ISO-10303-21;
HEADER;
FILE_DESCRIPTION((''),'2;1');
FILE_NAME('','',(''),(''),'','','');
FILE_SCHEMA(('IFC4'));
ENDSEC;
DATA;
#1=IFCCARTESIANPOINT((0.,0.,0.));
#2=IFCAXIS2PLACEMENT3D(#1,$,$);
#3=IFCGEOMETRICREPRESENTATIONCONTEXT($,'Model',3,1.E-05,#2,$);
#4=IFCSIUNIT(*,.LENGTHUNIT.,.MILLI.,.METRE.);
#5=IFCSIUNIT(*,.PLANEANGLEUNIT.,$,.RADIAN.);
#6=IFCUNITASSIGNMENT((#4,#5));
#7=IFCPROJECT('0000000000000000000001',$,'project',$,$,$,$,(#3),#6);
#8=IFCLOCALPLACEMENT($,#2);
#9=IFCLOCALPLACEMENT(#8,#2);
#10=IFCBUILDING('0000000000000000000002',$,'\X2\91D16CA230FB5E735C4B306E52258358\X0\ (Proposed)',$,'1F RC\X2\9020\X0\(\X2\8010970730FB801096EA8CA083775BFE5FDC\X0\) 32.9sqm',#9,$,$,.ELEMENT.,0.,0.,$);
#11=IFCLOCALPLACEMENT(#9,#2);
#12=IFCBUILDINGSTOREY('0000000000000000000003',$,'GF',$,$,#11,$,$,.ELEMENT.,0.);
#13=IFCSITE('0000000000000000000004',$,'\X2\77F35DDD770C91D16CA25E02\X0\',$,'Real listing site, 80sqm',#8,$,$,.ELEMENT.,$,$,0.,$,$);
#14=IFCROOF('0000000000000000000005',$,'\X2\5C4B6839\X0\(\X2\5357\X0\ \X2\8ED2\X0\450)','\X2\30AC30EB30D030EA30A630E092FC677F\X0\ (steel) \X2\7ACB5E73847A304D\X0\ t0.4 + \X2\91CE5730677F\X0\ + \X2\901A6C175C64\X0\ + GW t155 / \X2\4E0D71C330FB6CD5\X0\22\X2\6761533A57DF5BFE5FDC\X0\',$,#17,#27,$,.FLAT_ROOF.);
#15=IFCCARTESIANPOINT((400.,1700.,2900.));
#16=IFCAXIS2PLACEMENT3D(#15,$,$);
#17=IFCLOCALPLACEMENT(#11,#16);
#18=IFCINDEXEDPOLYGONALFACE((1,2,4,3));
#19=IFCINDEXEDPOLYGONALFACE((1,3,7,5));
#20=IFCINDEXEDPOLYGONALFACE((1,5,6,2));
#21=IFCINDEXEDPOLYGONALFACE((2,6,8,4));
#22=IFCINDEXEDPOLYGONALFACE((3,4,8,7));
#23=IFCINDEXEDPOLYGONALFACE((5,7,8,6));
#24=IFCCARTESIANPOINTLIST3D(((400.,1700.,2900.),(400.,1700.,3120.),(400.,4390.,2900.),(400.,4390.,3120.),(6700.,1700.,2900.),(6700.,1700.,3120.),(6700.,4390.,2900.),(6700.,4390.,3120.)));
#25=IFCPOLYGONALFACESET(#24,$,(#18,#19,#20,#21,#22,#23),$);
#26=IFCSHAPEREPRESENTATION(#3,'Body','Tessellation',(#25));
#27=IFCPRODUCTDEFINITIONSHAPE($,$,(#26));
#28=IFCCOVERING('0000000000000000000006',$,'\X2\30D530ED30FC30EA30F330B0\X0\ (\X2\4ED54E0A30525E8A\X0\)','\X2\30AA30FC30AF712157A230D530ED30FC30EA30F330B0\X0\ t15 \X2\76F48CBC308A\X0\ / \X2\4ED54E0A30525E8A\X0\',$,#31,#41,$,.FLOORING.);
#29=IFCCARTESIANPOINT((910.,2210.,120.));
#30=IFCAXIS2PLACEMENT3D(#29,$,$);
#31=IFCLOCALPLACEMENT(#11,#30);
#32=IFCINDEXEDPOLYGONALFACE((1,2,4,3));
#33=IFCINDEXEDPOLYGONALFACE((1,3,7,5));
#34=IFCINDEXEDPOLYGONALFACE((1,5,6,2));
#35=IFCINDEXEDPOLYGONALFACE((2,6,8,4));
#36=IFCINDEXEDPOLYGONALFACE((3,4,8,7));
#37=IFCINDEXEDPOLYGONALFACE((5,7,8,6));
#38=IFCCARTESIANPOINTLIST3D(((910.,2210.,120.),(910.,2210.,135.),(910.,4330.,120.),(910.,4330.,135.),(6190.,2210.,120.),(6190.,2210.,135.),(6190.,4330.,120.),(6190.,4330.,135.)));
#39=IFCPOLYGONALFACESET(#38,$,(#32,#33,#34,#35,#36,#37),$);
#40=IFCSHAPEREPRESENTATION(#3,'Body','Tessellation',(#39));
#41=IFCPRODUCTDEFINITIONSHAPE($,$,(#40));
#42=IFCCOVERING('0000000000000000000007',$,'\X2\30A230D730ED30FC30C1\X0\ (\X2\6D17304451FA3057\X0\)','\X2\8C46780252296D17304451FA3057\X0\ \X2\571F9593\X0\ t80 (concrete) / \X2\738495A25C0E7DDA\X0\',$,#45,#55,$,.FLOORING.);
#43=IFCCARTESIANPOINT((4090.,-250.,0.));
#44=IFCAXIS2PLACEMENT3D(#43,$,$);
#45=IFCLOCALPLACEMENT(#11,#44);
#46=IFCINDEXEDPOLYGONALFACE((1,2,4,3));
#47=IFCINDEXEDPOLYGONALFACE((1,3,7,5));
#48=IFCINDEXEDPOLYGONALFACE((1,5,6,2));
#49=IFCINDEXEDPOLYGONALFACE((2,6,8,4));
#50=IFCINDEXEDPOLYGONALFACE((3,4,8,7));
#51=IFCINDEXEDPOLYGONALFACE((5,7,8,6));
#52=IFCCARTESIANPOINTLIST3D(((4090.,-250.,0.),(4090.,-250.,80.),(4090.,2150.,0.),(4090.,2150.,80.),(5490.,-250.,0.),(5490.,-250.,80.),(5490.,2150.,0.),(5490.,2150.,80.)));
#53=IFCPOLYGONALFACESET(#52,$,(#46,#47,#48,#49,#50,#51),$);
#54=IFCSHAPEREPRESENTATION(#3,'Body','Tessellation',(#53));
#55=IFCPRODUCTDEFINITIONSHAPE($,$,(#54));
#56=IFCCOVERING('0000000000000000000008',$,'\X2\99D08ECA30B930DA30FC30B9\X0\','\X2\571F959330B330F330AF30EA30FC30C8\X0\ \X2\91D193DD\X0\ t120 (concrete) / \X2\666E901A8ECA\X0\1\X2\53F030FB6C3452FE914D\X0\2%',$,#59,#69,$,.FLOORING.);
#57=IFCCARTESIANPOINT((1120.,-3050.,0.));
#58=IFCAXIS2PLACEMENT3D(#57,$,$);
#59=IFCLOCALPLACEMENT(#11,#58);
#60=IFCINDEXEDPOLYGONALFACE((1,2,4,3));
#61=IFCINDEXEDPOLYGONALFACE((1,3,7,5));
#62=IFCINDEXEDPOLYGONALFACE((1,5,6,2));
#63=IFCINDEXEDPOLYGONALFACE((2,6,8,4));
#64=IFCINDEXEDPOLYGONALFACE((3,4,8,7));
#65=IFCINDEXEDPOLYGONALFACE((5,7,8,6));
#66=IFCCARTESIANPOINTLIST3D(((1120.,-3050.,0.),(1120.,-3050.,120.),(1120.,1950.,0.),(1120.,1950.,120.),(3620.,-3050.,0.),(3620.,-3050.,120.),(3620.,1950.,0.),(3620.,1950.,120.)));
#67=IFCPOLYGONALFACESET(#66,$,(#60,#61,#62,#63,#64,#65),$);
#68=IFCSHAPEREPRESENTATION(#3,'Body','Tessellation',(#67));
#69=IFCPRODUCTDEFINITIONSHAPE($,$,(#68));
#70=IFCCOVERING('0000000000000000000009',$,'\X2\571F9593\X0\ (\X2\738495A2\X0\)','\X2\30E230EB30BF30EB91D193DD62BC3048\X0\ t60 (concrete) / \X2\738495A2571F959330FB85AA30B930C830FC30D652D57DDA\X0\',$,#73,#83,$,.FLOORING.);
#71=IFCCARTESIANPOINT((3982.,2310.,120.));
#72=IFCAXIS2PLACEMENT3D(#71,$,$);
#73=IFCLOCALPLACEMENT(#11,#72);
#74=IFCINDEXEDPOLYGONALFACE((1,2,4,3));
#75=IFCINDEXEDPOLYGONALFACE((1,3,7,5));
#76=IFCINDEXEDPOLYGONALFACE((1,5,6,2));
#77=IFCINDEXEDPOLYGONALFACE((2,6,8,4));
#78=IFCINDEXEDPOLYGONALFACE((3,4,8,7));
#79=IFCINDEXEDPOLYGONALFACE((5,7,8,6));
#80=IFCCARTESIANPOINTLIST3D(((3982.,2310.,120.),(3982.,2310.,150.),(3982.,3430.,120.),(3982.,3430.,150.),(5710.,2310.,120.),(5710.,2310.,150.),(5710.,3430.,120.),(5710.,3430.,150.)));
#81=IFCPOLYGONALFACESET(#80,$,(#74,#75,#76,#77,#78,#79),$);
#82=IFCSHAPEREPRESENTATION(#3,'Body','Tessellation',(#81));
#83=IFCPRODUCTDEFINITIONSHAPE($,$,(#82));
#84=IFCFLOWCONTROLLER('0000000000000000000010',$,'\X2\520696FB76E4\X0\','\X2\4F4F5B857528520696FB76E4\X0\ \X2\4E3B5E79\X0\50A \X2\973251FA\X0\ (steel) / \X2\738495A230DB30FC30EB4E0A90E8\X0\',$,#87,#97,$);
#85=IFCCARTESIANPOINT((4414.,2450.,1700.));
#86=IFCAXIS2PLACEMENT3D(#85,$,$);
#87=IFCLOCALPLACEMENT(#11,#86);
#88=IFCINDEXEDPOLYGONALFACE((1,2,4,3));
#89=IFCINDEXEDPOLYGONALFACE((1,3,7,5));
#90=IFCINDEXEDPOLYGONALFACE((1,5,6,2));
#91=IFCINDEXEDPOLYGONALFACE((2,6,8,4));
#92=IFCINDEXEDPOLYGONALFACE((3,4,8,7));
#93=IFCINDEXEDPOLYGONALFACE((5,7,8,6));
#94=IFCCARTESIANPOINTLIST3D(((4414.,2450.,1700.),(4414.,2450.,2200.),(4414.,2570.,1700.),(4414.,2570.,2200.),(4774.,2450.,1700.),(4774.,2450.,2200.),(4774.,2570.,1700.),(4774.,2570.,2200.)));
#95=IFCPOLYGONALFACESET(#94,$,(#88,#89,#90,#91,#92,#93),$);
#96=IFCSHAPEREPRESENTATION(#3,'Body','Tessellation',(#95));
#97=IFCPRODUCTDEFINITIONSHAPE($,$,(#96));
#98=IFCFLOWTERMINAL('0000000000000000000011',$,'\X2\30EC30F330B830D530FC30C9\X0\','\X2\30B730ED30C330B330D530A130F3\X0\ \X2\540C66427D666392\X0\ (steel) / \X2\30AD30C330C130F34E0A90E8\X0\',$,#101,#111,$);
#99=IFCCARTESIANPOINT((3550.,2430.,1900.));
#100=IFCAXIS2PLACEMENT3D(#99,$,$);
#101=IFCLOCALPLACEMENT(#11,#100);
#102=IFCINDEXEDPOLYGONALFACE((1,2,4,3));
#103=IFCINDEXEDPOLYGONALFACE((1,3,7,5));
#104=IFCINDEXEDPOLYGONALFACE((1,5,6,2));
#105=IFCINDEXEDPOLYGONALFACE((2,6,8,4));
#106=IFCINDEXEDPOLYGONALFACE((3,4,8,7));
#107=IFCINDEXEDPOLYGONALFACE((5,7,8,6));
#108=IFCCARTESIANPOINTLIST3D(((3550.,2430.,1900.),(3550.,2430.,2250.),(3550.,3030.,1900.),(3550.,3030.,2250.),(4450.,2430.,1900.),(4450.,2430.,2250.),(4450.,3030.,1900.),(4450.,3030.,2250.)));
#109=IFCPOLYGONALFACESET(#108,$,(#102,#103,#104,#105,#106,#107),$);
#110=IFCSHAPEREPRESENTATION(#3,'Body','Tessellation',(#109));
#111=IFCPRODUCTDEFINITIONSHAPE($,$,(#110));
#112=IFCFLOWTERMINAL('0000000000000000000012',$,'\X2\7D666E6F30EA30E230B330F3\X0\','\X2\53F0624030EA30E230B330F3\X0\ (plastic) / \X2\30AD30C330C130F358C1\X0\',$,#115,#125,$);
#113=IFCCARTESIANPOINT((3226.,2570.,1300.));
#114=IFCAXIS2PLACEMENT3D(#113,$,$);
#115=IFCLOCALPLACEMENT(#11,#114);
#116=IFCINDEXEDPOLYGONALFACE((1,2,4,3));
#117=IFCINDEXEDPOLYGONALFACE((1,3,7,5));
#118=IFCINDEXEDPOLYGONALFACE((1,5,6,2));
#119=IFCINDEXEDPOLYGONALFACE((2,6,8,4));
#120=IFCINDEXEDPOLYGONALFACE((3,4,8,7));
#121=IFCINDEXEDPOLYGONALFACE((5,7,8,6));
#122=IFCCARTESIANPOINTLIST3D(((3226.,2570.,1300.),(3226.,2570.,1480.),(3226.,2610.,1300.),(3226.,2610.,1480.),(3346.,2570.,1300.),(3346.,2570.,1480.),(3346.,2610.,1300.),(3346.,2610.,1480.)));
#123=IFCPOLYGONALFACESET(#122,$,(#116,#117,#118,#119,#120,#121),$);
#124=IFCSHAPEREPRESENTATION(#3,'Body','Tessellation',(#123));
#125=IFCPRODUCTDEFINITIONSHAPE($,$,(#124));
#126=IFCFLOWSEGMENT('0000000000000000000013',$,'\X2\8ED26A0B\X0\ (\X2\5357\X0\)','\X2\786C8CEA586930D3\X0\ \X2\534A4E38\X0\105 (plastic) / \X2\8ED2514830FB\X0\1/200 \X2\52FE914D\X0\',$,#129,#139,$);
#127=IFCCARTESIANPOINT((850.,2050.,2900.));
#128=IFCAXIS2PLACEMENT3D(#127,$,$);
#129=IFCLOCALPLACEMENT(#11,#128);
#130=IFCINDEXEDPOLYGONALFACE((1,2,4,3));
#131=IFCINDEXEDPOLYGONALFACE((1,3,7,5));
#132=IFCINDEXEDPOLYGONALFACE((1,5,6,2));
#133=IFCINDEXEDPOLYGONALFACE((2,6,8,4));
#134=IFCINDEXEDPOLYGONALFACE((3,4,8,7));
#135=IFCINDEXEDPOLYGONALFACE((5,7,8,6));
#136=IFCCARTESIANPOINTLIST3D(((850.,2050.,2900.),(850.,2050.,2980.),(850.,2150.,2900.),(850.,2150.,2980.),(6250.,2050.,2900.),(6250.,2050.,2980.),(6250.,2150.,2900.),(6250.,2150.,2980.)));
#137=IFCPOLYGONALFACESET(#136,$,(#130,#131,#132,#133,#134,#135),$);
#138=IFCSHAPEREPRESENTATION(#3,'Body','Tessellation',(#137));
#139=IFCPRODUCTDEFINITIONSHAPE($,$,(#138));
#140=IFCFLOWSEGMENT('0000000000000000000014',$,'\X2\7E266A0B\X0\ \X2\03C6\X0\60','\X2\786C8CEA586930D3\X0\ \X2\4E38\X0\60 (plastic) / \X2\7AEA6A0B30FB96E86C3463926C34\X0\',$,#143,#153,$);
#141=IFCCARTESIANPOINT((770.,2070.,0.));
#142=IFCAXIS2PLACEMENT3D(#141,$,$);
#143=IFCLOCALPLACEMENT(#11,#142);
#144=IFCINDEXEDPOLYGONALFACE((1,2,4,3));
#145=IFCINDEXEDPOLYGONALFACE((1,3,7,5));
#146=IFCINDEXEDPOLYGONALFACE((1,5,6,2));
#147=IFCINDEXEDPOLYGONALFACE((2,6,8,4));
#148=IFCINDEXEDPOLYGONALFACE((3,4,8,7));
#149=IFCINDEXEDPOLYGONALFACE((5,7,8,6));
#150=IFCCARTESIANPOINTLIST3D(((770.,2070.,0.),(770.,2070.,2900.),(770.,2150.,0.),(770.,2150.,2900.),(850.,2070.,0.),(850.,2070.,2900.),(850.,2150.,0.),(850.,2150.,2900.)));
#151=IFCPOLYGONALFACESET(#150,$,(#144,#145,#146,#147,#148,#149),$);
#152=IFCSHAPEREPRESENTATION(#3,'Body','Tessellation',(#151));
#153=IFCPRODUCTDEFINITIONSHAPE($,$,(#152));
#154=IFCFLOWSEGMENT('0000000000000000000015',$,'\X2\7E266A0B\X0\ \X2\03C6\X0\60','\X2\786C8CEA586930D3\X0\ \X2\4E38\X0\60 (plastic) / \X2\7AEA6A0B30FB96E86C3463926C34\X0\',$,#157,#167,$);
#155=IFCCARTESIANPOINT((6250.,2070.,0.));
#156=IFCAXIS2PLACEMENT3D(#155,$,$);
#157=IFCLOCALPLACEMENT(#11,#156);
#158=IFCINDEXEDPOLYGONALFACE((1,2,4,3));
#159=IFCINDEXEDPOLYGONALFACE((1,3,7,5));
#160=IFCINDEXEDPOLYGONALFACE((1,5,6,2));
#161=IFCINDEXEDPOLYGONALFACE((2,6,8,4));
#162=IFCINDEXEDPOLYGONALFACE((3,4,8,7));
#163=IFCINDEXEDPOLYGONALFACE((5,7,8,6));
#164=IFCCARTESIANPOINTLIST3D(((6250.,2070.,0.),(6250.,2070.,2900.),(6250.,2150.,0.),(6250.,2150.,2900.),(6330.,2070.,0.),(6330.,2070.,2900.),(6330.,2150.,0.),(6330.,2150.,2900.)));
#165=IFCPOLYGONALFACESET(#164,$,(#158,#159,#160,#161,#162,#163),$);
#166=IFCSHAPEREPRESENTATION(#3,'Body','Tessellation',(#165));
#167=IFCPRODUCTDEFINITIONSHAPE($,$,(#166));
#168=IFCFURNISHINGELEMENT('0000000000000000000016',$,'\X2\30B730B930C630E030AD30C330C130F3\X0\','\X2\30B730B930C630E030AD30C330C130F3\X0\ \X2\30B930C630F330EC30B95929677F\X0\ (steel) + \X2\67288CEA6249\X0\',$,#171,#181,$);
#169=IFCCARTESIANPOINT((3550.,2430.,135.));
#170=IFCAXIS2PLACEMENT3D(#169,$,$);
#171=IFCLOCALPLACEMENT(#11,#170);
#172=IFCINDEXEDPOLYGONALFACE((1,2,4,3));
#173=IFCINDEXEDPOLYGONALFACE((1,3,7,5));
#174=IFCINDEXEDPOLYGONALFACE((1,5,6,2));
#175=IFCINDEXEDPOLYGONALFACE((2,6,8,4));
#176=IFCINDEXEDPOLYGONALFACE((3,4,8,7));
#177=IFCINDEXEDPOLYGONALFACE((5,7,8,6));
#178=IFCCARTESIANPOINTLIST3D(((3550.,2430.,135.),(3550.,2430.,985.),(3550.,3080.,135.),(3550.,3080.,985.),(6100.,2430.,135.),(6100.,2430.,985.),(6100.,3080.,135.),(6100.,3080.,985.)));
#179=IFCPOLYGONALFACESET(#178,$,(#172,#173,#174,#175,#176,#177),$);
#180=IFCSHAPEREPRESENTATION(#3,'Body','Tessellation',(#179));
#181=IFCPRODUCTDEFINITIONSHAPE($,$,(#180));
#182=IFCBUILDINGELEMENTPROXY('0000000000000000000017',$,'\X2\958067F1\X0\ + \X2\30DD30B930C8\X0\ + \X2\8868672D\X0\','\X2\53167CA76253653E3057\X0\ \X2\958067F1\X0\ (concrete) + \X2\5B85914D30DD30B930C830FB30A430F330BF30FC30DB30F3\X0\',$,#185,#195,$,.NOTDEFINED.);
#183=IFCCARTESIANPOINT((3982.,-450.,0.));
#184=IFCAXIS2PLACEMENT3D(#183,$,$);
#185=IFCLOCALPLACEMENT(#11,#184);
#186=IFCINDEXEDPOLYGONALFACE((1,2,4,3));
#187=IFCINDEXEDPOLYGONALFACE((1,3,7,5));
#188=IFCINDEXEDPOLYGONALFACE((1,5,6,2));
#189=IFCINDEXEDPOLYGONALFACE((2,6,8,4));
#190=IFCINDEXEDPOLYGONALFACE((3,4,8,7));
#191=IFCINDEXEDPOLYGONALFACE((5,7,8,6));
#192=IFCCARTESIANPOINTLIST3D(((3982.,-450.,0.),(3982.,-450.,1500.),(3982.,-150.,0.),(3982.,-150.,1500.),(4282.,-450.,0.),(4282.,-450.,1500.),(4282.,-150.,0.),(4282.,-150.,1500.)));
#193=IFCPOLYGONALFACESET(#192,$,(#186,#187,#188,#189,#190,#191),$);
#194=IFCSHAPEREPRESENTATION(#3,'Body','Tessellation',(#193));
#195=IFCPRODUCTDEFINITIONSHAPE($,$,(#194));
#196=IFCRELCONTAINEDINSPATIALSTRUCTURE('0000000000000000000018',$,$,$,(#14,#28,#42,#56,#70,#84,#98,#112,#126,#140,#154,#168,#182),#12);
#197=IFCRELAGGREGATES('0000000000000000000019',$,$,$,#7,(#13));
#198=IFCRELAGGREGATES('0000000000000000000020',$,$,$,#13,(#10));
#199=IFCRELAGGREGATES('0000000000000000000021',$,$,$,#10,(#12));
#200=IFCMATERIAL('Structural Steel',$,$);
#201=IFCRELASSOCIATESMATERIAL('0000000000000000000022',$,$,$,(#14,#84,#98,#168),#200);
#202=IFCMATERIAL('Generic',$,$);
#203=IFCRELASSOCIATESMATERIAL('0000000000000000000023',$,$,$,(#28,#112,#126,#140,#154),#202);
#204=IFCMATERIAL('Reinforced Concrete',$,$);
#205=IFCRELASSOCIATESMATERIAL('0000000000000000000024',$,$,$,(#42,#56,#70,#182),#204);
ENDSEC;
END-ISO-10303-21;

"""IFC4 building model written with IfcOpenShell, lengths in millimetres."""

from ifc_helpers import new_model, si_unit, frame, frame_2d, origin, place, context, project, spatial, rectangle, extrude, material, element, save


model = new_model("IFC4")

# Units and contexts
model_context = context("Model", 3, precision=1e-05, world=origin())
ifc_project = project(units=[si_unit("LENGTHUNIT", "METRE", prefix="MILLI"), si_unit("PLANEANGLEUNIT", "RADIAN")], contexts=[model_context])

# Site, building, storey
site_placement = place(None, origin())
site = spatial("IfcSite", under=ifc_project, at=site_placement, Name="石川県金沢市", ObjectType="Real listing site, 80sqm", CompositionType="ELEMENT", RefElevation=0.0)
building_placement = place(site_placement, origin())
building = spatial("IfcBuilding", under=site, at=building_placement, Name="金沢・平屋の別荘 (Proposed)", ObjectType="1F RC造(耐震・耐雪負荷対応) 32.9sqm", CompositionType="ELEMENT", ElevationOfRefHeight=0.0, ElevationOfTerrain=0.0)
storey_placement = place(building_placement, origin())
storey = spatial("IfcBuildingStorey", under=building, at=storey_placement, Name="GF", CompositionType="ELEMENT", Elevation=0.0)

# Shared definitions
ifc_material_1 = material(Name="Reinforced Concrete")

# Roof
ifc_material_2 = material(Name="Structural Steel")
roof_placement = place(storey_placement, frame((400.0, 1700.0, 2900.0)))
element("IfcRoof", 1, at=roof_placement, inside=storey, material=ifc_material_2, Name="屋根(南 軒450)", Description="ガルバリウム鋼板 (steel) 立平葺き t0.4 + 野地板 + 通気層 + GW t155 / 不燃・法22条区域対応", PredefinedType="FLAT_ROOF", context=model_context, shape_type="SweptSolid", body=[
    extrude(rectangle(XDim=6300.0, YDim=2690.0, at=frame_2d((3150.0, 1345.0))), frame((400.0, 1700.0, 2900.0)), (0.0, 0.0, 1.0), 220.0),
])

# Coverings
ifc_material_3 = material(Name="Generic")
covering_1_placement = place(storey_placement, frame((910.0, 2210.0, 120.0)))
element("IfcCovering", 2, at=covering_1_placement, inside=storey, material=ifc_material_3, Name="フローリング (仕上げ床)", Description="オーク無垢フローリング t15 直貼り / 仕上げ床", PredefinedType="FLOORING", context=model_context, shape_type="SweptSolid", body=[
    extrude(rectangle(XDim=5280.0, YDim=2120.0, at=frame_2d((2640.0, 1060.0))), frame((910.0, 2210.0, 120.0)), (0.0, 0.0, 1.0), 15.0),
])
covering_2_placement = place(storey_placement, frame((4090.0, -250.0, 0.0)))
element("IfcCovering", 3, at=covering_2_placement, inside=storey, material=ifc_material_1, Name="アプローチ (洗い出し)", Description="豆砂利洗い出し 土間 t80 (concrete) / 玄関導線", PredefinedType="FLOORING", context=model_context, shape_type="SweptSolid", body=[
    extrude(rectangle(XDim=1400.0, YDim=2400.0, at=frame_2d((700.0, 1200.0))), frame((4090.0, -250.0, 0.0)), (0.0, 0.0, 1.0), 80.0),
])
covering_3_placement = place(storey_placement, frame((1120.0, -3050.0, 0.0)))
element("IfcCovering", 4, at=covering_3_placement, inside=storey, material=ifc_material_1, Name="駐車スペース", Description="土間コンクリート 金鏝 t120 (concrete) / 普通車1台・水勾配2%", PredefinedType="FLOORING", context=model_context, shape_type="SweptSolid", body=[
    extrude(rectangle(XDim=2500.0, YDim=5000.0, at=frame_2d((1250.0, 2500.0))), frame((1120.0, -3050.0, 0.0)), (0.0, 0.0, 1.0), 120.0),
])
covering_4_placement = place(storey_placement, frame((3982.0, 2310.0, 120.0)))
element("IfcCovering", 5, at=covering_4_placement, inside=storey, material=ifc_material_1, Name="土間 (玄関)", Description="モルタル金鏝押え t60 (concrete) / 玄関土間・薪ストーブ動線", PredefinedType="FLOORING", context=model_context, shape_type="SweptSolid", body=[
    extrude(rectangle(XDim=1728.0, YDim=1120.0, at=frame_2d((864.0, 560.0))), frame((3982.0, 2310.0, 120.0)), (0.0, 0.0, 1.0), 30.0),
])

# Flow controller
flow_controller_placement = place(storey_placement, frame((4414.0, 2450.0, 1700.0)))
element("IfcFlowController", 6, at=flow_controller_placement, inside=storey, material=ifc_material_2, Name="分電盤", Description="住宅用分電盤 主幹50A 露出 (steel) / 玄関ホール上部", context=model_context, shape_type="SweptSolid", body=[
    extrude(rectangle(XDim=360.0, YDim=120.0, at=frame_2d((180.0, 60.0))), frame((4414.0, 2450.0, 1700.0)), (0.0, 0.0, 1.0), 500.0),
])

# Flow terminals
flow_terminal_1_placement = place(storey_placement, frame((3550.0, 2430.0, 1900.0)))
element("IfcFlowTerminal", 7, at=flow_terminal_1_placement, inside=storey, material=ifc_material_2, Name="レンジフード", Description="シロッコファン 同時給排 (steel) / キッチン上部", context=model_context, shape_type="SweptSolid", body=[
    extrude(rectangle(XDim=900.0, YDim=600.0, at=frame_2d((450.0, 300.0))), frame((3550.0, 2430.0, 1900.0)), (0.0, 0.0, 1.0), 350.0),
])
flow_terminal_2_placement = place(storey_placement, frame((3226.0, 2570.0, 1300.0)))
element("IfcFlowTerminal", 8, at=flow_terminal_2_placement, inside=storey, material=ifc_material_3, Name="給湯リモコン", Description="台所リモコン (plastic) / キッチン壁", context=model_context, shape_type="SweptSolid", body=[
    extrude(rectangle(XDim=120.0, YDim=40.0, at=frame_2d((60.0, 20.0))), frame((3226.0, 2570.0, 1300.0)), (0.0, 0.0, 1.0), 180.0),
])

# Flow segments
flow_segment_1_placement = place(storey_placement, frame((850.0, 2050.0, 2900.0)))
element("IfcFlowSegment", 9, at=flow_segment_1_placement, inside=storey, material=ifc_material_3, Name="軒樋 (南)", Description="硬質塩ビ 半丸105 (plastic) / 軒先・1/200 勾配", context=model_context, shape_type="SweptSolid", body=[
    extrude(rectangle(XDim=5400.0, YDim=100.0, at=frame_2d((2700.0, 50.0))), frame((850.0, 2050.0, 2900.0)), (0.0, 0.0, 1.0), 80.0),
])
flow_segment_2_placement = place(storey_placement, frame((770.0, 2070.0, 0.0)))
element("IfcFlowSegment", 10, at=flow_segment_2_placement, inside=storey, material=ifc_material_3, Name="縦樋 φ60", Description="硬質塩ビ 丸60 (plastic) / 竪樋・雨水排水", context=model_context, shape_type="SweptSolid", body=[
    extrude(rectangle(XDim=80.0, YDim=80.0, at=frame_2d((40.0, 40.0))), frame((770.0, 2070.0, 0.0)), (0.0, 0.0, 1.0), 2900.0),
])
flow_segment_3_placement = place(storey_placement, frame((6250.0, 2070.0, 0.0)))
element("IfcFlowSegment", 11, at=flow_segment_3_placement, inside=storey, material=ifc_material_3, Name="縦樋 φ60", Description="硬質塩ビ 丸60 (plastic) / 竪樋・雨水排水", context=model_context, shape_type="SweptSolid", body=[
    extrude(rectangle(XDim=80.0, YDim=80.0, at=frame_2d((40.0, 40.0))), frame((6250.0, 2070.0, 0.0)), (0.0, 0.0, 1.0), 2900.0),
])

# Furnishing element
furnishing_placement = place(storey_placement, frame((3550.0, 2430.0, 135.0)))
element("IfcFurnishingElement", 12, at=furnishing_placement, inside=storey, material=ifc_material_2, Name="システムキッチン", Description="システムキッチン ステンレス天板 (steel) + 木質扉", context=model_context, shape_type="SweptSolid", body=[
    extrude(rectangle(XDim=2550.0, YDim=650.0, at=frame_2d((1275.0, 325.0))), frame((3550.0, 2430.0, 135.0)), (0.0, 0.0, 1.0), 850.0),
])

# Building element proxy
proxy_placement = place(storey_placement, frame((3982.0, -450.0, 0.0)))
element("IfcBuildingElementProxy", 13, at=proxy_placement, inside=storey, material=ifc_material_1, Name="門柱 + ポスト + 表札", Description="化粧打放し 門柱 (concrete) + 宅配ポスト・インターホン", PredefinedType="NOTDEFINED", context=model_context, shape_type="SweptSolid", body=[
    extrude(rectangle(XDim=300.0, YDim=300.0, at=frame_2d((150.0, 150.0))), frame((3982.0, -450.0, 0.0)), (0.0, 0.0, 1.0), 1500.0),
])

save(model, "model.ifc")
